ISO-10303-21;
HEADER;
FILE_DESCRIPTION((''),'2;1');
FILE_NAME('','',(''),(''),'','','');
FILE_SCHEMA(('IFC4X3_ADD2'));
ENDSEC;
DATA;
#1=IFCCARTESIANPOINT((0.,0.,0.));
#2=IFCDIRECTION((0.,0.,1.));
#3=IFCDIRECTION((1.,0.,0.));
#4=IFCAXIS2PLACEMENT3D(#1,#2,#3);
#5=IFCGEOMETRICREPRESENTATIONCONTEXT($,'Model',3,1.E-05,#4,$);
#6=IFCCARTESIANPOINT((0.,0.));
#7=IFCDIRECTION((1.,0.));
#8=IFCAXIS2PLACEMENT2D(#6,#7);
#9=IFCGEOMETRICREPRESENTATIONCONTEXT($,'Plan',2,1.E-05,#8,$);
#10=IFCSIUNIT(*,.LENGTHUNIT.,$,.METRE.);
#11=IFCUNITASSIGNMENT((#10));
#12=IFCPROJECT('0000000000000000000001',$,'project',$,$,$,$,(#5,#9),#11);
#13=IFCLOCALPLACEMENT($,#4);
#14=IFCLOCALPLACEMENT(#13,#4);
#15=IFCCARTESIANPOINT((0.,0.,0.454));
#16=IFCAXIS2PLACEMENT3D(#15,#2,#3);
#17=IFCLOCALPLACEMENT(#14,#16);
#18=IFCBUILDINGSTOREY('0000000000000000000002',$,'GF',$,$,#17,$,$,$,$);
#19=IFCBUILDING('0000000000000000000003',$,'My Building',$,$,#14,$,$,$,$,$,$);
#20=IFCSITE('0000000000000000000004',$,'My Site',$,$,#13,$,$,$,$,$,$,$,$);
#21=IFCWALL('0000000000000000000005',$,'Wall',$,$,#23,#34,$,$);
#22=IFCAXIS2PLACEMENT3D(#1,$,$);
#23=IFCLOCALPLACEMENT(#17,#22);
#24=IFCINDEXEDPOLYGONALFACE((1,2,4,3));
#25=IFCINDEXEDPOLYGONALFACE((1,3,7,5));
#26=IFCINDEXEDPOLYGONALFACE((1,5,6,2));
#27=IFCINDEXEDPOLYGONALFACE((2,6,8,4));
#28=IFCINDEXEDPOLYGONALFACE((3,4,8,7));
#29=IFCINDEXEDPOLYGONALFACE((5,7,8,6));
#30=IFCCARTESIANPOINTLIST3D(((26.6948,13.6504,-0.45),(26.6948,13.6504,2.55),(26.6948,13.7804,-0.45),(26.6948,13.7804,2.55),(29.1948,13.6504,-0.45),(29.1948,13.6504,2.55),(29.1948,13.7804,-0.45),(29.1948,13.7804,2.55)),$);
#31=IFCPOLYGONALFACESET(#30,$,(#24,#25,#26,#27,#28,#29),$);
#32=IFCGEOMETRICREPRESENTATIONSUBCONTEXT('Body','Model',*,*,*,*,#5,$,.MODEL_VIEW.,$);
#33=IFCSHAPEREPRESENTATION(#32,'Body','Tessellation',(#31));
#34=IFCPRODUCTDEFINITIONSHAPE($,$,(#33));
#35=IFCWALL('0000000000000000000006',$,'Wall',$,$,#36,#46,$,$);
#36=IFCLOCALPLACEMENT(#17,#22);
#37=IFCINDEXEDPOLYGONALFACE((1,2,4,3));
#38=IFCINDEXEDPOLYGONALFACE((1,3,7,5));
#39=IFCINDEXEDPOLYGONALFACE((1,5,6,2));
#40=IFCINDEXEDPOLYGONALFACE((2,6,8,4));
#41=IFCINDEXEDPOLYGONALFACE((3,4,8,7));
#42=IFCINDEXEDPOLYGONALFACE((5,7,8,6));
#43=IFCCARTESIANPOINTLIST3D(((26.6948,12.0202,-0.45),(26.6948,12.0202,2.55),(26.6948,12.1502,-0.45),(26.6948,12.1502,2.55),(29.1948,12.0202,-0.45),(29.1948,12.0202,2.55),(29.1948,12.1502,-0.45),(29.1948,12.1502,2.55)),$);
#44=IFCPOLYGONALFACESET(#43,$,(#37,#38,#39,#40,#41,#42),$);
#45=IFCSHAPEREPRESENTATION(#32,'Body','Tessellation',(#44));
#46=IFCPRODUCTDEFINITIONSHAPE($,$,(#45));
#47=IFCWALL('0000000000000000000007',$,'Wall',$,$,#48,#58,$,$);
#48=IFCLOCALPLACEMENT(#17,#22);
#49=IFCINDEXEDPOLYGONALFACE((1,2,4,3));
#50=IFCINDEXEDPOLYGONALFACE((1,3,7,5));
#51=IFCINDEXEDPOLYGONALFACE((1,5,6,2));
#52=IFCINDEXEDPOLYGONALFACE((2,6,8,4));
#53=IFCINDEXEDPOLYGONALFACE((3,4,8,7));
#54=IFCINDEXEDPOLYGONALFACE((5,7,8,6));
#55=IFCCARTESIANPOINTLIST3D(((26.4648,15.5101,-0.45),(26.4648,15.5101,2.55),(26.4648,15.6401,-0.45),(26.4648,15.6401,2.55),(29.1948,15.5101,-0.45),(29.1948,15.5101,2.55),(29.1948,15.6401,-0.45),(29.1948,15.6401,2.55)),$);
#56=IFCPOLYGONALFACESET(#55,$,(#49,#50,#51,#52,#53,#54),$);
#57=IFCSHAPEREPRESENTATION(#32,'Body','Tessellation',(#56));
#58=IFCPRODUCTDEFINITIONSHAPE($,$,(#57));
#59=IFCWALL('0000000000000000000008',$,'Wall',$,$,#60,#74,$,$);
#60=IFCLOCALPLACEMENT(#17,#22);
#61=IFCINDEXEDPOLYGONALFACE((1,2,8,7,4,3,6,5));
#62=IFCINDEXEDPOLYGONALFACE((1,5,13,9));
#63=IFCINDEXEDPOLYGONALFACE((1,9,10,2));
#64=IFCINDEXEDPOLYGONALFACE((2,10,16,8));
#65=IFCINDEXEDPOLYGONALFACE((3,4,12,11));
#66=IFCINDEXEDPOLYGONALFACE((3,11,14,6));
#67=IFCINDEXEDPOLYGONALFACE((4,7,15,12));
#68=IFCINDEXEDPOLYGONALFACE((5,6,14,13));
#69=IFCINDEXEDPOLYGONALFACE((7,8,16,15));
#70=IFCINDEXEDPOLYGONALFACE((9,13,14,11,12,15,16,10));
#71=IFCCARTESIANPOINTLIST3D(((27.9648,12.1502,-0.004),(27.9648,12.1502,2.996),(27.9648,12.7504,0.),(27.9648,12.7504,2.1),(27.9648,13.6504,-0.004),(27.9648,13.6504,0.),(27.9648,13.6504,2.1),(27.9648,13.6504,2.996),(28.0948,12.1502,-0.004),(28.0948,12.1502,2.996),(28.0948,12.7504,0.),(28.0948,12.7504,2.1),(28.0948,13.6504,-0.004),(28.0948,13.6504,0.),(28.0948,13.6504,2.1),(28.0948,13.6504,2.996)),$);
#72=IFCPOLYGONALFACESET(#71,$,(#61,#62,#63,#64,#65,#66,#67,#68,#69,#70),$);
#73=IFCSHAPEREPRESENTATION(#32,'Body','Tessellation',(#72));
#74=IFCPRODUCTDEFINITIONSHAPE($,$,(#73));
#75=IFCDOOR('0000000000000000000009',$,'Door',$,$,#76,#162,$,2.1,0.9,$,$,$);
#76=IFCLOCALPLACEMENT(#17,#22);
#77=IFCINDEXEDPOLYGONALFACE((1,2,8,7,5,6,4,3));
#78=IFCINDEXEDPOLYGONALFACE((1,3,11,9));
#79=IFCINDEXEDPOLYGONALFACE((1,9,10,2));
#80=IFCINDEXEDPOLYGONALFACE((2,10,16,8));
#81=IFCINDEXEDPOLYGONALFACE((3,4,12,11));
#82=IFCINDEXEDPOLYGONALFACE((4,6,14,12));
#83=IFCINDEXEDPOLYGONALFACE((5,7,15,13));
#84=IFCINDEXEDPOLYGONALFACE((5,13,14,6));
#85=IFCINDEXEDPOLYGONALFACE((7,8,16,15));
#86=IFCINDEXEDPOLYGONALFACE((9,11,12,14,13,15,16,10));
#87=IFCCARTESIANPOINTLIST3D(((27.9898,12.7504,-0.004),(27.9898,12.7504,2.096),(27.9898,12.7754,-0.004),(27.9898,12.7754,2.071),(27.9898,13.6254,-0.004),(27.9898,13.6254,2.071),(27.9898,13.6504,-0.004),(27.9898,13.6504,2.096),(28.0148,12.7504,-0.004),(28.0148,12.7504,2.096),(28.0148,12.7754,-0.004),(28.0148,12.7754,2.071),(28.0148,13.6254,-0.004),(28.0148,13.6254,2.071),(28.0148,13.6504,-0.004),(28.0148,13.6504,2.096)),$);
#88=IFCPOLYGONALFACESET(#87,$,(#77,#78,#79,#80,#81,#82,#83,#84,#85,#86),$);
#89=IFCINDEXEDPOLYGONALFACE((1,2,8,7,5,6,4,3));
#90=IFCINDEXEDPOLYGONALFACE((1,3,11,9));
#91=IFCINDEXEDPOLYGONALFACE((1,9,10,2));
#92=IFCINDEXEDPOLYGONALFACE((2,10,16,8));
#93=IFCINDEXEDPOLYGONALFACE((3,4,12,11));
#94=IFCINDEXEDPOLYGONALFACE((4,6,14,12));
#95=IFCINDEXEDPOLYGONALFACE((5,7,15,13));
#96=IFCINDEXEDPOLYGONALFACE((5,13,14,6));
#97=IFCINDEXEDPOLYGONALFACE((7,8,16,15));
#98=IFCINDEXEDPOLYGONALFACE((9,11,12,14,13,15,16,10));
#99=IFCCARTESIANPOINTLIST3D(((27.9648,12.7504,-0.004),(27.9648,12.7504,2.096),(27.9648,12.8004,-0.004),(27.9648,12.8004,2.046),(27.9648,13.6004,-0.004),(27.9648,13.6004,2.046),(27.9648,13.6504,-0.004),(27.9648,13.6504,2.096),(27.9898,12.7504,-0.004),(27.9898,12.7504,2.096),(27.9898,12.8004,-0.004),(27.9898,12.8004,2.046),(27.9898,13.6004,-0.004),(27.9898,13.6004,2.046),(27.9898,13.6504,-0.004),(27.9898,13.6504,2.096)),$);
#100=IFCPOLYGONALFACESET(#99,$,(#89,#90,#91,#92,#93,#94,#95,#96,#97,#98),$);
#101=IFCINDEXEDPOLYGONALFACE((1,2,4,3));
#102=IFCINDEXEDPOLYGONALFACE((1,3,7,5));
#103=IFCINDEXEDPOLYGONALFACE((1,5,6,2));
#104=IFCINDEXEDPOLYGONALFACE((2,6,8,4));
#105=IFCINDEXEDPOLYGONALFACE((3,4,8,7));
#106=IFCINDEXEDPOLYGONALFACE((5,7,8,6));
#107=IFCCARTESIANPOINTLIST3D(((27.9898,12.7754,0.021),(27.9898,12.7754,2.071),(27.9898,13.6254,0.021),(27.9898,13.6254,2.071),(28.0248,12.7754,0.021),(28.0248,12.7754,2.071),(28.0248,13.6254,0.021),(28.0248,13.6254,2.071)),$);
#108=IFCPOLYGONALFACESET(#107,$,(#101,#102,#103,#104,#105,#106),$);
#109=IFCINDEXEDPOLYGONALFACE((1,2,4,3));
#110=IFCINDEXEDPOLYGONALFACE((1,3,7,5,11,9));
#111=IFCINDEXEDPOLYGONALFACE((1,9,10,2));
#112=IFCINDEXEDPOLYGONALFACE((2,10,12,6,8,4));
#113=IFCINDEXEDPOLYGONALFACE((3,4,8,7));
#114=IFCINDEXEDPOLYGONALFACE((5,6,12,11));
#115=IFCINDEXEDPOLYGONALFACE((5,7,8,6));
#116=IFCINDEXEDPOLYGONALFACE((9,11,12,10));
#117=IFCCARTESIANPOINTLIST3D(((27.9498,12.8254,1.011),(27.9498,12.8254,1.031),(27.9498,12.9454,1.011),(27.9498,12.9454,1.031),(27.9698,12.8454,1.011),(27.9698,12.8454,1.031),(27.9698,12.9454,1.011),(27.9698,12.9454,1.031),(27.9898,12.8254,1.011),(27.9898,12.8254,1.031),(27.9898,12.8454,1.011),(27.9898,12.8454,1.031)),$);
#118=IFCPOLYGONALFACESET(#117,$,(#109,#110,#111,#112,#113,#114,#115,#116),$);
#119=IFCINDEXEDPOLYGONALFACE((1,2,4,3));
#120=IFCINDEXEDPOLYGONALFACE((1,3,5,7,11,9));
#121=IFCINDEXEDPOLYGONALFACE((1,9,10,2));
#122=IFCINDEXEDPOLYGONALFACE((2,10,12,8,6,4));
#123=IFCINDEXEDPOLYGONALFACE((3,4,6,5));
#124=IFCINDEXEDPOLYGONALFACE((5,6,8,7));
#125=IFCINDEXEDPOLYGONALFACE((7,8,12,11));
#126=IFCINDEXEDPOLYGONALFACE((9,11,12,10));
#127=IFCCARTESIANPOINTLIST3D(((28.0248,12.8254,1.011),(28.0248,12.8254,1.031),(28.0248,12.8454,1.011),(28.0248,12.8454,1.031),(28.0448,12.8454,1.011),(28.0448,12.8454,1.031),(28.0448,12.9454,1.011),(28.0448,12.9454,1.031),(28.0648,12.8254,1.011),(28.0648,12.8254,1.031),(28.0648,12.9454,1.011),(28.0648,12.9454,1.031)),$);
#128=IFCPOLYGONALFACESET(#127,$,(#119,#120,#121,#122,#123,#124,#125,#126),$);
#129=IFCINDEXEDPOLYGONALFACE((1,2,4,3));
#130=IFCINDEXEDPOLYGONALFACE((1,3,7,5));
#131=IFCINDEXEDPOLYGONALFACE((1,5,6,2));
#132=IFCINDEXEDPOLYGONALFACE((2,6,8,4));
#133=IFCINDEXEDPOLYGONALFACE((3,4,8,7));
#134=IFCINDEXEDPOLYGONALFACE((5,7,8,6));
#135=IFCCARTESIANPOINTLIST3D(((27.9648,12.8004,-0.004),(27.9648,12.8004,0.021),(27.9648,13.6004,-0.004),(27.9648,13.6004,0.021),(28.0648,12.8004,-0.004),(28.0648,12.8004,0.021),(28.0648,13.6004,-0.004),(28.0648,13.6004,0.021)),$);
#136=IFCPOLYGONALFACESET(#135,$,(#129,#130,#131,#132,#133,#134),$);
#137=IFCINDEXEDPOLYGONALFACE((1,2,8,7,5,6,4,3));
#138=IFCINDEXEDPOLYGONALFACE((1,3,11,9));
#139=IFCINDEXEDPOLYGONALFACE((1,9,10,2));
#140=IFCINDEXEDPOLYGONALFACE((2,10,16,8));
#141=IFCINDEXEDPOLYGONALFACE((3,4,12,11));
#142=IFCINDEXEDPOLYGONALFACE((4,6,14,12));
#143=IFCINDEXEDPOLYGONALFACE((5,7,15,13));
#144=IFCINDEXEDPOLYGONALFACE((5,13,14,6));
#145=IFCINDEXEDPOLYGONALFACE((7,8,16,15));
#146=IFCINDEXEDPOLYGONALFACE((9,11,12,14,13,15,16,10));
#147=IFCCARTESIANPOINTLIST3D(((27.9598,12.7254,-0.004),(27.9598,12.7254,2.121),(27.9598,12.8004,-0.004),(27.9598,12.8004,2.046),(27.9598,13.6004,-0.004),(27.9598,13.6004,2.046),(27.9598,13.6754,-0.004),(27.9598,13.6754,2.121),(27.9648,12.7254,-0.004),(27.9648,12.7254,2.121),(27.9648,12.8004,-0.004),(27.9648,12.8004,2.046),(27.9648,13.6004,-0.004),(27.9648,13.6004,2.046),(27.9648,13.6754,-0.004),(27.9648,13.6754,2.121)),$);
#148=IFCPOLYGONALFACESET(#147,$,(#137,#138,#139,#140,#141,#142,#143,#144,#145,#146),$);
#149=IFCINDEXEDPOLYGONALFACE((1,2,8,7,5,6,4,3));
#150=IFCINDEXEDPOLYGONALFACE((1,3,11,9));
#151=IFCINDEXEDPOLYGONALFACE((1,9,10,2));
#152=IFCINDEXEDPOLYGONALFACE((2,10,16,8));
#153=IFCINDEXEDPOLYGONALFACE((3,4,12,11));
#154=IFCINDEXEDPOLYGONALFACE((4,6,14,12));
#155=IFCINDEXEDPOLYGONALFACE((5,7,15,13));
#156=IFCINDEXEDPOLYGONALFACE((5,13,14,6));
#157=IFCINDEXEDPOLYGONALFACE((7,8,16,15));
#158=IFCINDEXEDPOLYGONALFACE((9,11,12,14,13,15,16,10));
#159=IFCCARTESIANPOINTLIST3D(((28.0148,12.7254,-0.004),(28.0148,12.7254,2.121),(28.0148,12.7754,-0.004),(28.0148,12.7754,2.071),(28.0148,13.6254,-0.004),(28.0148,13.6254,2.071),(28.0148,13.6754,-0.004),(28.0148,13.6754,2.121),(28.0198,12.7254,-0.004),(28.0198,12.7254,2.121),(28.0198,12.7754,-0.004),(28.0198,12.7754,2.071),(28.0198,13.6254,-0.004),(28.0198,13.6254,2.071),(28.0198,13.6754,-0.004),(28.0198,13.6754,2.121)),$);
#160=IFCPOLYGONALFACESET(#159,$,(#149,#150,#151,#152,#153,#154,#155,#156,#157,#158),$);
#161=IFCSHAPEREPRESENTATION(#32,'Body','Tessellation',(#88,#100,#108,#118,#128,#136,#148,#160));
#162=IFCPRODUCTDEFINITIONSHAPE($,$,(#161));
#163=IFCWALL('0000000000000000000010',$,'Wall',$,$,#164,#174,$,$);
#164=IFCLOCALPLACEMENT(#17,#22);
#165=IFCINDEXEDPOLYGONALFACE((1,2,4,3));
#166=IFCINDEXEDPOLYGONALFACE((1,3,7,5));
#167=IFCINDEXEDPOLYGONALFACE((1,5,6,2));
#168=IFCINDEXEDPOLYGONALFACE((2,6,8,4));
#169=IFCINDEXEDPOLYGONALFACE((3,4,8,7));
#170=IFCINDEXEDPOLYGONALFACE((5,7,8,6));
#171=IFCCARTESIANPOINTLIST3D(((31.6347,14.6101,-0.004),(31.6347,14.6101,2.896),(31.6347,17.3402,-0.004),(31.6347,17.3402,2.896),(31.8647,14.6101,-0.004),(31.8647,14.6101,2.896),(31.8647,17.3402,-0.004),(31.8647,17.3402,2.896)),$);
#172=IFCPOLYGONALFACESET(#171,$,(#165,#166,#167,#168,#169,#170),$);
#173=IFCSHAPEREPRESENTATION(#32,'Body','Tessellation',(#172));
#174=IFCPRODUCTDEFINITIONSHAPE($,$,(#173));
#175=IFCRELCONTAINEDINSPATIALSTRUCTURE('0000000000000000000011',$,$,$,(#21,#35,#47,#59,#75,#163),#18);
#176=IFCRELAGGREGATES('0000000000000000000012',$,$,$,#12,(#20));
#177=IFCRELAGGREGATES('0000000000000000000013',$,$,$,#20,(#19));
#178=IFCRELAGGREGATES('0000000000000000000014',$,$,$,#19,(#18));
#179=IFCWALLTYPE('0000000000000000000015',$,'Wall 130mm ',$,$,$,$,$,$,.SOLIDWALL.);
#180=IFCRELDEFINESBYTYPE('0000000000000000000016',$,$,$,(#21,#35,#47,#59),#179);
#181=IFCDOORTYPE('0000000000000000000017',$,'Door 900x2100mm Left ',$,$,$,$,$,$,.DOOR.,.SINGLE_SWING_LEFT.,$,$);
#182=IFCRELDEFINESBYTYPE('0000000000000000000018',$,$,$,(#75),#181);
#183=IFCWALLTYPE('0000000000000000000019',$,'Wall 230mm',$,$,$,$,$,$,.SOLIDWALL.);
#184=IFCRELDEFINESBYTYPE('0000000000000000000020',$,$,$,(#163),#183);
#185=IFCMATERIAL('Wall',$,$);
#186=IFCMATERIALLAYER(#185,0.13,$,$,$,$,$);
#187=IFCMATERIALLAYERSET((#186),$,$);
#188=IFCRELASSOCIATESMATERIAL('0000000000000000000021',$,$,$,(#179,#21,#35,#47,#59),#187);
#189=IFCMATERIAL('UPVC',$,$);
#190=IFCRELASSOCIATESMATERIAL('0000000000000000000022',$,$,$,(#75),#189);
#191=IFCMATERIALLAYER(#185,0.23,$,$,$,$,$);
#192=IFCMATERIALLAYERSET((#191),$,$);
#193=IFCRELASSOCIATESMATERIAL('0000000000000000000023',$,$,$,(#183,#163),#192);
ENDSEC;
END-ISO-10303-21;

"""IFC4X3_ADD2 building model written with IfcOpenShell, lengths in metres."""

from ifc_helpers import new_model, entity, si_unit, frame, origin_with_axes, origin_2d_with_axis, place, context, subcontext, project, spatial, line, indexed_curve, outline, extrude, shape, source, transform, mapped, material, layer, layer_set, layer_usage, type_object, type_shapes, element, fill, save


model = new_model("IFC4X3_ADD2")

# Units and contexts
model_context = context("Model", 3, precision=1e-05, world=origin_with_axes())
plan_context = context("Plan", 2, precision=1e-05, world=origin_2d_with_axis())
body_context_1 = subcontext(model_context, "Body", "Model", "MODEL_VIEW")
body_context_2 = subcontext(plan_context, "Body", "Plan", "PLAN_VIEW")
ifc_project = project(units=[si_unit("LENGTHUNIT", "METRE")], contexts=[model_context, plan_context])

# Site, building, storey
site_placement = place(None, origin_with_axes())
site = spatial("IfcSite", under=ifc_project, at=site_placement, Name="My Site")
building_placement = place(site_placement, origin_with_axes())
building = spatial("IfcBuilding", under=site, at=building_placement, Name="My Building")
storey_placement = place(building_placement, frame((0.0, 0.0, 0.454), z_axis=(0.0, 0.0, 1.0), x_axis=(1.0, 0.0, 0.0)))
storey = spatial("IfcBuildingStorey", under=building, at=storey_placement, Name="GF")

# Walls
ifc_material_1 = material(Name="Wall")
ifc_layer_1 = layer(ifc_material_1, 0.13)
ifc_layer_set_1 = layer_set([ifc_layer_1])
ifc_layer_usage_1 = layer_usage(ifc_layer_set_1, "AXIS2", "POSITIVE", 0.0)
wall_type_1 = type_object("IfcWallType", Name="Wall 130mm ", PredefinedType="SOLIDWALL", material=ifc_layer_set_1)
wall_1_placement = place(storey_placement, frame((29.1948, 13.7804, -0.45), z_axis=(0.0, 0.0, 1.0), x_axis=(-1.0, 0.0, 0.0)))
element("IfcWall", 1, at=wall_1_placement, inside=storey, type_object=wall_type_1, material=ifc_layer_usage_1, Name="Wall", context=body_context_1, shape_type="SweptSolid", body=[
    extrude(outline(indexed_curve([(0.0, 0.0), (0.0, 0.13), (2.5, 0.13), (2.5, 0.0), (0.0, 0.0)], self_intersect=False)), origin_with_axes(), (0.0, 0.0, 1.0), 3.0),
])
ifc_layer_usage_2 = layer_usage(ifc_layer_set_1, "AXIS2", "POSITIVE", 0.0)
wall_2_placement = place(storey_placement, frame((29.1948, 12.1502, -0.45), z_axis=(0.0, 0.0, 1.0), x_axis=(-1.0, 0.0, 0.0)))
element("IfcWall", 2, at=wall_2_placement, inside=storey, type_object=wall_type_1, material=ifc_layer_usage_2, Name="Wall", context=body_context_1, shape_type="SweptSolid", body=[
    extrude(outline(indexed_curve([(0.0, 0.0), (0.0, 0.13), (2.5, 0.13), (2.5, 0.0), (0.0, 0.0)], self_intersect=False)), origin_with_axes(), (0.0, 0.0, 1.0), 3.0),
])
ifc_layer_usage_3 = layer_usage(ifc_layer_set_1, "AXIS2", "POSITIVE", 0.0)
wall_3_placement = place(storey_placement, frame((29.1948, 15.6401, -0.45), z_axis=(0.0, 0.0, 1.0), x_axis=(-1.0, 0.0, 0.0)))
element("IfcWall", 3, at=wall_3_placement, inside=storey, type_object=wall_type_1, material=ifc_layer_usage_3, Name="Wall", context=body_context_1, shape_type="SweptSolid", body=[
    extrude(outline(indexed_curve([(0.0, 0.0), (0.0, 0.13), (2.73, 0.13), (2.73, 0.0), (0.0, 0.0)], self_intersect=False)), origin_with_axes(), (0.0, 0.0, 1.0), 3.0),
])

# Wall, opening, door
ifc_layer_usage_4 = layer_usage(ifc_layer_set_1, "AXIS2", "POSITIVE", 0.0)
wall_4_placement = place(storey_placement, frame((27.9648, 13.6504, -0.004), z_axis=(0.0, 0.0, 1.0), x_axis=(0.0, -1.0, 0.0)))
wall_4 = element("IfcWall", 4, at=wall_4_placement, inside=storey, type_object=wall_type_1, material=ifc_layer_usage_4, Name="Wall", context=body_context_1, shape_type="SweptSolid", body=[
    extrude(outline(indexed_curve([(0.0, 0.0), (0.0, 0.13), (1.5002, 0.13), (1.5002, 0.0), (0.0, 0.0)], self_intersect=False)), origin_with_axes(), (0.0, 0.0, 1.0), 3.0),
])
shared_shape_1 = source(origin_with_axes(), body_context_1, "Body", "SweptSolid", [
    extrude(outline(indexed_curve([(0.0, 0.0), (0.9, 0.0), (0.9, 2.1), (0.0, 2.1)], segments=[line(1, 2, 3, 4, 1)])), frame((0.0, -0.6, 0.0), z_axis=(0.0, -1.0, 0.0), x_axis=(1.0, 0.0, 0.0)), (0.0, 0.0, -1.0), 1.2),
])
opening_1_placement = place(wall_4_placement, frame((0.0, 0.0, 0.004), z_axis=(0.0, 0.0, 1.0), x_axis=(1.0, 0.0, 0.0)))
opening_1 = element("IfcOpeningElement", 5, at=opening_1_placement, cuts=wall_4, PredefinedType="OPENING", context=body_context_1, shape_type="MappedRepresentation", body=[
    mapped(shared_shape_1, transform((0.0, 0.0, 0.0), x_axis=(1.0, 0.0, 0.0), y_axis=(0.0, 1.0, 0.0), z_axis=(0.0, 0.0, 1.0), scale=1.0)),
])
ifc_material_2 = material(Name="UPVC")
door_type_1 = type_object("IfcDoorType", Name="Door 900x2100mm Left ", OperationType="SINGLE_SWING_LEFT", PredefinedType="DOOR")
shared_shape_2 = source(origin_with_axes(), body_context_1, "Body", "SweptSolid", [
    extrude(outline(indexed_curve([(0.0, 0.0), (0.0, 2.1), (0.9, 2.1), (0.9, 0.0), (0.875, 0.0), (0.875, 2.075), (0.025, 2.075), (0.025, 0.0)], segments=[line(1, 2, 3, 4, 5, 6, 7, 8, 1)])), frame((0.0, 0.025, 0.0), z_axis=(0.0, -1.0, 0.0), x_axis=(1.0, 0.0, 0.0)), (0.0, 0.0, -1.0), 0.025),
    extrude(outline(indexed_curve([(0.0, 0.0), (0.0, 2.1), (0.9, 2.1), (0.9, 0.0), (0.85, 0.0), (0.85, 2.05), (0.05, 2.05), (0.05, 0.0)], segments=[line(1, 2, 3, 4, 5, 6, 7, 8, 1)])), frame((0.0, 0.0, 0.0), z_axis=(0.0, -1.0, 0.0), x_axis=(1.0, 0.0, 0.0)), (0.0, 0.0, -1.0), 0.025),
    extrude(outline(indexed_curve([(0.0, 0.0), (0.85, 0.0), (0.85, 0.035), (0.0, 0.035)], segments=[line(1, 2, 3, 4, 1)])), frame((0.025, 0.025, 0.025), z_axis=(0.0, 0.0, 1.0), x_axis=(1.0, 0.0, 0.0)), (0.0, 0.0, 1.0), 2.05),
    extrude(outline(indexed_curve([(0.0, 0.0), (0.0, -0.04), (-0.12, -0.04), (-0.12, -0.02), (-0.02, -0.02), (-0.02, 0.0)], segments=[line(1, 2, 3, 4, 5, 6, 1)])), frame((0.825, 0.025, 1.015), z_axis=(0.0, 0.0, 1.0), x_axis=(1.0, 0.0, 0.0)), (0.0, 0.0, 1.0), 0.02),
    extrude(outline(indexed_curve([(0.0, 0.0), (0.0, 0.04), (-0.12, 0.04), (-0.12, 0.02), (-0.02, 0.02), (-0.02, 0.0)], segments=[line(1, 2, 3, 4, 5, 6, 1)])), frame((0.825, 0.06, 1.015), z_axis=(0.0, 0.0, 1.0), x_axis=(1.0, 0.0, 0.0)), (0.0, 0.0, 1.0), 0.02),
    extrude(outline(indexed_curve([(0.0, 0.0), (0.8, 0.0), (0.8, 0.1), (0.0, 0.1)], segments=[line(1, 2, 3, 4, 1)])), frame((0.05, 0.0, 0.0), z_axis=(0.0, 0.0, 1.0), x_axis=(1.0, 0.0, 0.0)), (0.0, 0.0, 1.0), 0.025),
    extrude(outline(indexed_curve([(0.0, 0.0), (0.0, 2.125), (0.95, 2.125), (0.95, 0.0), (0.875, 0.0), (0.875, 2.05), (0.075, 2.05), (0.075, 0.0)], segments=[line(1, 2, 3, 4, 5, 6, 7, 8, 1)])), frame((-0.025, -0.005, 0.0), z_axis=(0.0, -1.0, 0.0), x_axis=(1.0, 0.0, 0.0)), (0.0, 0.0, -1.0), 0.005),
    extrude(outline(indexed_curve([(0.0, 0.0), (0.0, 2.125), (0.95, 2.125), (0.95, 0.0), (0.9, 0.0), (0.9, 2.075), (0.05, 2.075), (0.05, 0.0)], segments=[line(1, 2, 3, 4, 5, 6, 7, 8, 1)])), frame((-0.025, 0.05, 0.0), z_axis=(0.0, -1.0, 0.0), x_axis=(1.0, 0.0, 0.0)), (0.0, 0.0, -1.0), 0.005),
])
shared_shape_3 = source(origin_with_axes(), body_context_2, "Body", "Curve2D", [
    entity("IfcIndexedPolyCurve", entity("IfcCartesianPointList2D", [[0.0, 0.0], [0.0, 0.05], [0.025, 0.05], [0.025, 0.025], [0.05, 0.025], [0.05, 0.0]]), [entity("IfcLineIndex", [1, 2, 3, 4, 5, 6, 1])]),
    entity("IfcIndexedPolyCurve", entity("IfcCartesianPointList2D", [[0.9, 0.0], [0.9, 0.05], [0.875, 0.05], [0.875, 0.025], [0.85, 0.025], [0.85, 0.0]]), [entity("IfcLineIndex", [1, 2, 3, 4, 5, 6, 1])]),
    entity("IfcTrimmedCurve", entity("IfcEllipse", entity("IfcAxis2Placement2D", entity("IfcCartesianPoint", [0.06, 0.05]), entity("IfcDirection", [1.0, 0.0])), 0.815, 0.85), [entity("IfcCartesianPoint", [0.875, 0.05])], [entity("IfcCartesianPoint", [0.06, 0.9])], True, "CARTESIAN"),
    entity("IfcIndexedPolyCurve", entity("IfcCartesianPointList2D", [[0.025, 0.05], [0.06, 0.05], [0.06, 0.9], [0.025, 0.9]]), [entity("IfcLineIndex", [1, 2, 3, 4, 1])]),
])
type_shapes(door_type_1, [shared_shape_2, shared_shape_3])
door_1_placement = place(opening_1_placement, frame((0.0, 0.0, -0.004), z_axis=(0.0, 0.0, 1.0), x_axis=(1.0, 0.0, 0.0)))
door_1 = element("IfcDoor", 6, at=door_1_placement, inside=storey, type_object=door_type_1, material=ifc_material_2, Name="Door", OverallHeight=2.1, OverallWidth=0.9, shapes=[
    shape(body_context_1, "Body", "MappedRepresentation", [mapped(shared_shape_2, transform((0.0, 0.0, 0.0), x_axis=(1.0, 0.0, 0.0), y_axis=(0.0, 1.0, 0.0), z_axis=(0.0, 0.0, 1.0), scale=1.0))]),
    shape(body_context_2, "Body", "MappedRepresentation", [mapped(shared_shape_3, transform((0.0, 0.0, 0.0), x_axis=(1.0, 0.0, 0.0), y_axis=(0.0, 1.0, 0.0), z_axis=(0.0, 0.0, 1.0), scale=1.0))]),
])
fill(opening_1, door_1)

# Wall
ifc_layer_2 = layer(ifc_material_1, 0.23)
ifc_layer_set_2 = layer_set([ifc_layer_2])
ifc_layer_usage_5 = layer_usage(ifc_layer_set_2, "AXIS2", "POSITIVE", 0.0)
wall_type_2 = type_object("IfcWallType", Name="Wall 230mm", PredefinedType="SOLIDWALL", material=ifc_layer_set_2)
wall_5_placement = place(storey_placement, frame((31.8647, 14.6101, -0.004), z_axis=(0.0, 0.0, 1.0), x_axis=(0.000001, 1.0, 0.0)))
element("IfcWall", 7, at=wall_5_placement, inside=storey, type_object=wall_type_2, material=ifc_layer_usage_5, Name="Wall", context=body_context_1, shape_type="SweptSolid", body=[
    extrude(outline(indexed_curve([(0.0, 0.0), (0.0, 0.23), (2.73, 0.23), (2.73, 0.0), (0.0, 0.0)], self_intersect=False)), origin_with_axes(), (0.0, 0.0, 1.0), 2.9),
])

save(model, "model.ifc")
